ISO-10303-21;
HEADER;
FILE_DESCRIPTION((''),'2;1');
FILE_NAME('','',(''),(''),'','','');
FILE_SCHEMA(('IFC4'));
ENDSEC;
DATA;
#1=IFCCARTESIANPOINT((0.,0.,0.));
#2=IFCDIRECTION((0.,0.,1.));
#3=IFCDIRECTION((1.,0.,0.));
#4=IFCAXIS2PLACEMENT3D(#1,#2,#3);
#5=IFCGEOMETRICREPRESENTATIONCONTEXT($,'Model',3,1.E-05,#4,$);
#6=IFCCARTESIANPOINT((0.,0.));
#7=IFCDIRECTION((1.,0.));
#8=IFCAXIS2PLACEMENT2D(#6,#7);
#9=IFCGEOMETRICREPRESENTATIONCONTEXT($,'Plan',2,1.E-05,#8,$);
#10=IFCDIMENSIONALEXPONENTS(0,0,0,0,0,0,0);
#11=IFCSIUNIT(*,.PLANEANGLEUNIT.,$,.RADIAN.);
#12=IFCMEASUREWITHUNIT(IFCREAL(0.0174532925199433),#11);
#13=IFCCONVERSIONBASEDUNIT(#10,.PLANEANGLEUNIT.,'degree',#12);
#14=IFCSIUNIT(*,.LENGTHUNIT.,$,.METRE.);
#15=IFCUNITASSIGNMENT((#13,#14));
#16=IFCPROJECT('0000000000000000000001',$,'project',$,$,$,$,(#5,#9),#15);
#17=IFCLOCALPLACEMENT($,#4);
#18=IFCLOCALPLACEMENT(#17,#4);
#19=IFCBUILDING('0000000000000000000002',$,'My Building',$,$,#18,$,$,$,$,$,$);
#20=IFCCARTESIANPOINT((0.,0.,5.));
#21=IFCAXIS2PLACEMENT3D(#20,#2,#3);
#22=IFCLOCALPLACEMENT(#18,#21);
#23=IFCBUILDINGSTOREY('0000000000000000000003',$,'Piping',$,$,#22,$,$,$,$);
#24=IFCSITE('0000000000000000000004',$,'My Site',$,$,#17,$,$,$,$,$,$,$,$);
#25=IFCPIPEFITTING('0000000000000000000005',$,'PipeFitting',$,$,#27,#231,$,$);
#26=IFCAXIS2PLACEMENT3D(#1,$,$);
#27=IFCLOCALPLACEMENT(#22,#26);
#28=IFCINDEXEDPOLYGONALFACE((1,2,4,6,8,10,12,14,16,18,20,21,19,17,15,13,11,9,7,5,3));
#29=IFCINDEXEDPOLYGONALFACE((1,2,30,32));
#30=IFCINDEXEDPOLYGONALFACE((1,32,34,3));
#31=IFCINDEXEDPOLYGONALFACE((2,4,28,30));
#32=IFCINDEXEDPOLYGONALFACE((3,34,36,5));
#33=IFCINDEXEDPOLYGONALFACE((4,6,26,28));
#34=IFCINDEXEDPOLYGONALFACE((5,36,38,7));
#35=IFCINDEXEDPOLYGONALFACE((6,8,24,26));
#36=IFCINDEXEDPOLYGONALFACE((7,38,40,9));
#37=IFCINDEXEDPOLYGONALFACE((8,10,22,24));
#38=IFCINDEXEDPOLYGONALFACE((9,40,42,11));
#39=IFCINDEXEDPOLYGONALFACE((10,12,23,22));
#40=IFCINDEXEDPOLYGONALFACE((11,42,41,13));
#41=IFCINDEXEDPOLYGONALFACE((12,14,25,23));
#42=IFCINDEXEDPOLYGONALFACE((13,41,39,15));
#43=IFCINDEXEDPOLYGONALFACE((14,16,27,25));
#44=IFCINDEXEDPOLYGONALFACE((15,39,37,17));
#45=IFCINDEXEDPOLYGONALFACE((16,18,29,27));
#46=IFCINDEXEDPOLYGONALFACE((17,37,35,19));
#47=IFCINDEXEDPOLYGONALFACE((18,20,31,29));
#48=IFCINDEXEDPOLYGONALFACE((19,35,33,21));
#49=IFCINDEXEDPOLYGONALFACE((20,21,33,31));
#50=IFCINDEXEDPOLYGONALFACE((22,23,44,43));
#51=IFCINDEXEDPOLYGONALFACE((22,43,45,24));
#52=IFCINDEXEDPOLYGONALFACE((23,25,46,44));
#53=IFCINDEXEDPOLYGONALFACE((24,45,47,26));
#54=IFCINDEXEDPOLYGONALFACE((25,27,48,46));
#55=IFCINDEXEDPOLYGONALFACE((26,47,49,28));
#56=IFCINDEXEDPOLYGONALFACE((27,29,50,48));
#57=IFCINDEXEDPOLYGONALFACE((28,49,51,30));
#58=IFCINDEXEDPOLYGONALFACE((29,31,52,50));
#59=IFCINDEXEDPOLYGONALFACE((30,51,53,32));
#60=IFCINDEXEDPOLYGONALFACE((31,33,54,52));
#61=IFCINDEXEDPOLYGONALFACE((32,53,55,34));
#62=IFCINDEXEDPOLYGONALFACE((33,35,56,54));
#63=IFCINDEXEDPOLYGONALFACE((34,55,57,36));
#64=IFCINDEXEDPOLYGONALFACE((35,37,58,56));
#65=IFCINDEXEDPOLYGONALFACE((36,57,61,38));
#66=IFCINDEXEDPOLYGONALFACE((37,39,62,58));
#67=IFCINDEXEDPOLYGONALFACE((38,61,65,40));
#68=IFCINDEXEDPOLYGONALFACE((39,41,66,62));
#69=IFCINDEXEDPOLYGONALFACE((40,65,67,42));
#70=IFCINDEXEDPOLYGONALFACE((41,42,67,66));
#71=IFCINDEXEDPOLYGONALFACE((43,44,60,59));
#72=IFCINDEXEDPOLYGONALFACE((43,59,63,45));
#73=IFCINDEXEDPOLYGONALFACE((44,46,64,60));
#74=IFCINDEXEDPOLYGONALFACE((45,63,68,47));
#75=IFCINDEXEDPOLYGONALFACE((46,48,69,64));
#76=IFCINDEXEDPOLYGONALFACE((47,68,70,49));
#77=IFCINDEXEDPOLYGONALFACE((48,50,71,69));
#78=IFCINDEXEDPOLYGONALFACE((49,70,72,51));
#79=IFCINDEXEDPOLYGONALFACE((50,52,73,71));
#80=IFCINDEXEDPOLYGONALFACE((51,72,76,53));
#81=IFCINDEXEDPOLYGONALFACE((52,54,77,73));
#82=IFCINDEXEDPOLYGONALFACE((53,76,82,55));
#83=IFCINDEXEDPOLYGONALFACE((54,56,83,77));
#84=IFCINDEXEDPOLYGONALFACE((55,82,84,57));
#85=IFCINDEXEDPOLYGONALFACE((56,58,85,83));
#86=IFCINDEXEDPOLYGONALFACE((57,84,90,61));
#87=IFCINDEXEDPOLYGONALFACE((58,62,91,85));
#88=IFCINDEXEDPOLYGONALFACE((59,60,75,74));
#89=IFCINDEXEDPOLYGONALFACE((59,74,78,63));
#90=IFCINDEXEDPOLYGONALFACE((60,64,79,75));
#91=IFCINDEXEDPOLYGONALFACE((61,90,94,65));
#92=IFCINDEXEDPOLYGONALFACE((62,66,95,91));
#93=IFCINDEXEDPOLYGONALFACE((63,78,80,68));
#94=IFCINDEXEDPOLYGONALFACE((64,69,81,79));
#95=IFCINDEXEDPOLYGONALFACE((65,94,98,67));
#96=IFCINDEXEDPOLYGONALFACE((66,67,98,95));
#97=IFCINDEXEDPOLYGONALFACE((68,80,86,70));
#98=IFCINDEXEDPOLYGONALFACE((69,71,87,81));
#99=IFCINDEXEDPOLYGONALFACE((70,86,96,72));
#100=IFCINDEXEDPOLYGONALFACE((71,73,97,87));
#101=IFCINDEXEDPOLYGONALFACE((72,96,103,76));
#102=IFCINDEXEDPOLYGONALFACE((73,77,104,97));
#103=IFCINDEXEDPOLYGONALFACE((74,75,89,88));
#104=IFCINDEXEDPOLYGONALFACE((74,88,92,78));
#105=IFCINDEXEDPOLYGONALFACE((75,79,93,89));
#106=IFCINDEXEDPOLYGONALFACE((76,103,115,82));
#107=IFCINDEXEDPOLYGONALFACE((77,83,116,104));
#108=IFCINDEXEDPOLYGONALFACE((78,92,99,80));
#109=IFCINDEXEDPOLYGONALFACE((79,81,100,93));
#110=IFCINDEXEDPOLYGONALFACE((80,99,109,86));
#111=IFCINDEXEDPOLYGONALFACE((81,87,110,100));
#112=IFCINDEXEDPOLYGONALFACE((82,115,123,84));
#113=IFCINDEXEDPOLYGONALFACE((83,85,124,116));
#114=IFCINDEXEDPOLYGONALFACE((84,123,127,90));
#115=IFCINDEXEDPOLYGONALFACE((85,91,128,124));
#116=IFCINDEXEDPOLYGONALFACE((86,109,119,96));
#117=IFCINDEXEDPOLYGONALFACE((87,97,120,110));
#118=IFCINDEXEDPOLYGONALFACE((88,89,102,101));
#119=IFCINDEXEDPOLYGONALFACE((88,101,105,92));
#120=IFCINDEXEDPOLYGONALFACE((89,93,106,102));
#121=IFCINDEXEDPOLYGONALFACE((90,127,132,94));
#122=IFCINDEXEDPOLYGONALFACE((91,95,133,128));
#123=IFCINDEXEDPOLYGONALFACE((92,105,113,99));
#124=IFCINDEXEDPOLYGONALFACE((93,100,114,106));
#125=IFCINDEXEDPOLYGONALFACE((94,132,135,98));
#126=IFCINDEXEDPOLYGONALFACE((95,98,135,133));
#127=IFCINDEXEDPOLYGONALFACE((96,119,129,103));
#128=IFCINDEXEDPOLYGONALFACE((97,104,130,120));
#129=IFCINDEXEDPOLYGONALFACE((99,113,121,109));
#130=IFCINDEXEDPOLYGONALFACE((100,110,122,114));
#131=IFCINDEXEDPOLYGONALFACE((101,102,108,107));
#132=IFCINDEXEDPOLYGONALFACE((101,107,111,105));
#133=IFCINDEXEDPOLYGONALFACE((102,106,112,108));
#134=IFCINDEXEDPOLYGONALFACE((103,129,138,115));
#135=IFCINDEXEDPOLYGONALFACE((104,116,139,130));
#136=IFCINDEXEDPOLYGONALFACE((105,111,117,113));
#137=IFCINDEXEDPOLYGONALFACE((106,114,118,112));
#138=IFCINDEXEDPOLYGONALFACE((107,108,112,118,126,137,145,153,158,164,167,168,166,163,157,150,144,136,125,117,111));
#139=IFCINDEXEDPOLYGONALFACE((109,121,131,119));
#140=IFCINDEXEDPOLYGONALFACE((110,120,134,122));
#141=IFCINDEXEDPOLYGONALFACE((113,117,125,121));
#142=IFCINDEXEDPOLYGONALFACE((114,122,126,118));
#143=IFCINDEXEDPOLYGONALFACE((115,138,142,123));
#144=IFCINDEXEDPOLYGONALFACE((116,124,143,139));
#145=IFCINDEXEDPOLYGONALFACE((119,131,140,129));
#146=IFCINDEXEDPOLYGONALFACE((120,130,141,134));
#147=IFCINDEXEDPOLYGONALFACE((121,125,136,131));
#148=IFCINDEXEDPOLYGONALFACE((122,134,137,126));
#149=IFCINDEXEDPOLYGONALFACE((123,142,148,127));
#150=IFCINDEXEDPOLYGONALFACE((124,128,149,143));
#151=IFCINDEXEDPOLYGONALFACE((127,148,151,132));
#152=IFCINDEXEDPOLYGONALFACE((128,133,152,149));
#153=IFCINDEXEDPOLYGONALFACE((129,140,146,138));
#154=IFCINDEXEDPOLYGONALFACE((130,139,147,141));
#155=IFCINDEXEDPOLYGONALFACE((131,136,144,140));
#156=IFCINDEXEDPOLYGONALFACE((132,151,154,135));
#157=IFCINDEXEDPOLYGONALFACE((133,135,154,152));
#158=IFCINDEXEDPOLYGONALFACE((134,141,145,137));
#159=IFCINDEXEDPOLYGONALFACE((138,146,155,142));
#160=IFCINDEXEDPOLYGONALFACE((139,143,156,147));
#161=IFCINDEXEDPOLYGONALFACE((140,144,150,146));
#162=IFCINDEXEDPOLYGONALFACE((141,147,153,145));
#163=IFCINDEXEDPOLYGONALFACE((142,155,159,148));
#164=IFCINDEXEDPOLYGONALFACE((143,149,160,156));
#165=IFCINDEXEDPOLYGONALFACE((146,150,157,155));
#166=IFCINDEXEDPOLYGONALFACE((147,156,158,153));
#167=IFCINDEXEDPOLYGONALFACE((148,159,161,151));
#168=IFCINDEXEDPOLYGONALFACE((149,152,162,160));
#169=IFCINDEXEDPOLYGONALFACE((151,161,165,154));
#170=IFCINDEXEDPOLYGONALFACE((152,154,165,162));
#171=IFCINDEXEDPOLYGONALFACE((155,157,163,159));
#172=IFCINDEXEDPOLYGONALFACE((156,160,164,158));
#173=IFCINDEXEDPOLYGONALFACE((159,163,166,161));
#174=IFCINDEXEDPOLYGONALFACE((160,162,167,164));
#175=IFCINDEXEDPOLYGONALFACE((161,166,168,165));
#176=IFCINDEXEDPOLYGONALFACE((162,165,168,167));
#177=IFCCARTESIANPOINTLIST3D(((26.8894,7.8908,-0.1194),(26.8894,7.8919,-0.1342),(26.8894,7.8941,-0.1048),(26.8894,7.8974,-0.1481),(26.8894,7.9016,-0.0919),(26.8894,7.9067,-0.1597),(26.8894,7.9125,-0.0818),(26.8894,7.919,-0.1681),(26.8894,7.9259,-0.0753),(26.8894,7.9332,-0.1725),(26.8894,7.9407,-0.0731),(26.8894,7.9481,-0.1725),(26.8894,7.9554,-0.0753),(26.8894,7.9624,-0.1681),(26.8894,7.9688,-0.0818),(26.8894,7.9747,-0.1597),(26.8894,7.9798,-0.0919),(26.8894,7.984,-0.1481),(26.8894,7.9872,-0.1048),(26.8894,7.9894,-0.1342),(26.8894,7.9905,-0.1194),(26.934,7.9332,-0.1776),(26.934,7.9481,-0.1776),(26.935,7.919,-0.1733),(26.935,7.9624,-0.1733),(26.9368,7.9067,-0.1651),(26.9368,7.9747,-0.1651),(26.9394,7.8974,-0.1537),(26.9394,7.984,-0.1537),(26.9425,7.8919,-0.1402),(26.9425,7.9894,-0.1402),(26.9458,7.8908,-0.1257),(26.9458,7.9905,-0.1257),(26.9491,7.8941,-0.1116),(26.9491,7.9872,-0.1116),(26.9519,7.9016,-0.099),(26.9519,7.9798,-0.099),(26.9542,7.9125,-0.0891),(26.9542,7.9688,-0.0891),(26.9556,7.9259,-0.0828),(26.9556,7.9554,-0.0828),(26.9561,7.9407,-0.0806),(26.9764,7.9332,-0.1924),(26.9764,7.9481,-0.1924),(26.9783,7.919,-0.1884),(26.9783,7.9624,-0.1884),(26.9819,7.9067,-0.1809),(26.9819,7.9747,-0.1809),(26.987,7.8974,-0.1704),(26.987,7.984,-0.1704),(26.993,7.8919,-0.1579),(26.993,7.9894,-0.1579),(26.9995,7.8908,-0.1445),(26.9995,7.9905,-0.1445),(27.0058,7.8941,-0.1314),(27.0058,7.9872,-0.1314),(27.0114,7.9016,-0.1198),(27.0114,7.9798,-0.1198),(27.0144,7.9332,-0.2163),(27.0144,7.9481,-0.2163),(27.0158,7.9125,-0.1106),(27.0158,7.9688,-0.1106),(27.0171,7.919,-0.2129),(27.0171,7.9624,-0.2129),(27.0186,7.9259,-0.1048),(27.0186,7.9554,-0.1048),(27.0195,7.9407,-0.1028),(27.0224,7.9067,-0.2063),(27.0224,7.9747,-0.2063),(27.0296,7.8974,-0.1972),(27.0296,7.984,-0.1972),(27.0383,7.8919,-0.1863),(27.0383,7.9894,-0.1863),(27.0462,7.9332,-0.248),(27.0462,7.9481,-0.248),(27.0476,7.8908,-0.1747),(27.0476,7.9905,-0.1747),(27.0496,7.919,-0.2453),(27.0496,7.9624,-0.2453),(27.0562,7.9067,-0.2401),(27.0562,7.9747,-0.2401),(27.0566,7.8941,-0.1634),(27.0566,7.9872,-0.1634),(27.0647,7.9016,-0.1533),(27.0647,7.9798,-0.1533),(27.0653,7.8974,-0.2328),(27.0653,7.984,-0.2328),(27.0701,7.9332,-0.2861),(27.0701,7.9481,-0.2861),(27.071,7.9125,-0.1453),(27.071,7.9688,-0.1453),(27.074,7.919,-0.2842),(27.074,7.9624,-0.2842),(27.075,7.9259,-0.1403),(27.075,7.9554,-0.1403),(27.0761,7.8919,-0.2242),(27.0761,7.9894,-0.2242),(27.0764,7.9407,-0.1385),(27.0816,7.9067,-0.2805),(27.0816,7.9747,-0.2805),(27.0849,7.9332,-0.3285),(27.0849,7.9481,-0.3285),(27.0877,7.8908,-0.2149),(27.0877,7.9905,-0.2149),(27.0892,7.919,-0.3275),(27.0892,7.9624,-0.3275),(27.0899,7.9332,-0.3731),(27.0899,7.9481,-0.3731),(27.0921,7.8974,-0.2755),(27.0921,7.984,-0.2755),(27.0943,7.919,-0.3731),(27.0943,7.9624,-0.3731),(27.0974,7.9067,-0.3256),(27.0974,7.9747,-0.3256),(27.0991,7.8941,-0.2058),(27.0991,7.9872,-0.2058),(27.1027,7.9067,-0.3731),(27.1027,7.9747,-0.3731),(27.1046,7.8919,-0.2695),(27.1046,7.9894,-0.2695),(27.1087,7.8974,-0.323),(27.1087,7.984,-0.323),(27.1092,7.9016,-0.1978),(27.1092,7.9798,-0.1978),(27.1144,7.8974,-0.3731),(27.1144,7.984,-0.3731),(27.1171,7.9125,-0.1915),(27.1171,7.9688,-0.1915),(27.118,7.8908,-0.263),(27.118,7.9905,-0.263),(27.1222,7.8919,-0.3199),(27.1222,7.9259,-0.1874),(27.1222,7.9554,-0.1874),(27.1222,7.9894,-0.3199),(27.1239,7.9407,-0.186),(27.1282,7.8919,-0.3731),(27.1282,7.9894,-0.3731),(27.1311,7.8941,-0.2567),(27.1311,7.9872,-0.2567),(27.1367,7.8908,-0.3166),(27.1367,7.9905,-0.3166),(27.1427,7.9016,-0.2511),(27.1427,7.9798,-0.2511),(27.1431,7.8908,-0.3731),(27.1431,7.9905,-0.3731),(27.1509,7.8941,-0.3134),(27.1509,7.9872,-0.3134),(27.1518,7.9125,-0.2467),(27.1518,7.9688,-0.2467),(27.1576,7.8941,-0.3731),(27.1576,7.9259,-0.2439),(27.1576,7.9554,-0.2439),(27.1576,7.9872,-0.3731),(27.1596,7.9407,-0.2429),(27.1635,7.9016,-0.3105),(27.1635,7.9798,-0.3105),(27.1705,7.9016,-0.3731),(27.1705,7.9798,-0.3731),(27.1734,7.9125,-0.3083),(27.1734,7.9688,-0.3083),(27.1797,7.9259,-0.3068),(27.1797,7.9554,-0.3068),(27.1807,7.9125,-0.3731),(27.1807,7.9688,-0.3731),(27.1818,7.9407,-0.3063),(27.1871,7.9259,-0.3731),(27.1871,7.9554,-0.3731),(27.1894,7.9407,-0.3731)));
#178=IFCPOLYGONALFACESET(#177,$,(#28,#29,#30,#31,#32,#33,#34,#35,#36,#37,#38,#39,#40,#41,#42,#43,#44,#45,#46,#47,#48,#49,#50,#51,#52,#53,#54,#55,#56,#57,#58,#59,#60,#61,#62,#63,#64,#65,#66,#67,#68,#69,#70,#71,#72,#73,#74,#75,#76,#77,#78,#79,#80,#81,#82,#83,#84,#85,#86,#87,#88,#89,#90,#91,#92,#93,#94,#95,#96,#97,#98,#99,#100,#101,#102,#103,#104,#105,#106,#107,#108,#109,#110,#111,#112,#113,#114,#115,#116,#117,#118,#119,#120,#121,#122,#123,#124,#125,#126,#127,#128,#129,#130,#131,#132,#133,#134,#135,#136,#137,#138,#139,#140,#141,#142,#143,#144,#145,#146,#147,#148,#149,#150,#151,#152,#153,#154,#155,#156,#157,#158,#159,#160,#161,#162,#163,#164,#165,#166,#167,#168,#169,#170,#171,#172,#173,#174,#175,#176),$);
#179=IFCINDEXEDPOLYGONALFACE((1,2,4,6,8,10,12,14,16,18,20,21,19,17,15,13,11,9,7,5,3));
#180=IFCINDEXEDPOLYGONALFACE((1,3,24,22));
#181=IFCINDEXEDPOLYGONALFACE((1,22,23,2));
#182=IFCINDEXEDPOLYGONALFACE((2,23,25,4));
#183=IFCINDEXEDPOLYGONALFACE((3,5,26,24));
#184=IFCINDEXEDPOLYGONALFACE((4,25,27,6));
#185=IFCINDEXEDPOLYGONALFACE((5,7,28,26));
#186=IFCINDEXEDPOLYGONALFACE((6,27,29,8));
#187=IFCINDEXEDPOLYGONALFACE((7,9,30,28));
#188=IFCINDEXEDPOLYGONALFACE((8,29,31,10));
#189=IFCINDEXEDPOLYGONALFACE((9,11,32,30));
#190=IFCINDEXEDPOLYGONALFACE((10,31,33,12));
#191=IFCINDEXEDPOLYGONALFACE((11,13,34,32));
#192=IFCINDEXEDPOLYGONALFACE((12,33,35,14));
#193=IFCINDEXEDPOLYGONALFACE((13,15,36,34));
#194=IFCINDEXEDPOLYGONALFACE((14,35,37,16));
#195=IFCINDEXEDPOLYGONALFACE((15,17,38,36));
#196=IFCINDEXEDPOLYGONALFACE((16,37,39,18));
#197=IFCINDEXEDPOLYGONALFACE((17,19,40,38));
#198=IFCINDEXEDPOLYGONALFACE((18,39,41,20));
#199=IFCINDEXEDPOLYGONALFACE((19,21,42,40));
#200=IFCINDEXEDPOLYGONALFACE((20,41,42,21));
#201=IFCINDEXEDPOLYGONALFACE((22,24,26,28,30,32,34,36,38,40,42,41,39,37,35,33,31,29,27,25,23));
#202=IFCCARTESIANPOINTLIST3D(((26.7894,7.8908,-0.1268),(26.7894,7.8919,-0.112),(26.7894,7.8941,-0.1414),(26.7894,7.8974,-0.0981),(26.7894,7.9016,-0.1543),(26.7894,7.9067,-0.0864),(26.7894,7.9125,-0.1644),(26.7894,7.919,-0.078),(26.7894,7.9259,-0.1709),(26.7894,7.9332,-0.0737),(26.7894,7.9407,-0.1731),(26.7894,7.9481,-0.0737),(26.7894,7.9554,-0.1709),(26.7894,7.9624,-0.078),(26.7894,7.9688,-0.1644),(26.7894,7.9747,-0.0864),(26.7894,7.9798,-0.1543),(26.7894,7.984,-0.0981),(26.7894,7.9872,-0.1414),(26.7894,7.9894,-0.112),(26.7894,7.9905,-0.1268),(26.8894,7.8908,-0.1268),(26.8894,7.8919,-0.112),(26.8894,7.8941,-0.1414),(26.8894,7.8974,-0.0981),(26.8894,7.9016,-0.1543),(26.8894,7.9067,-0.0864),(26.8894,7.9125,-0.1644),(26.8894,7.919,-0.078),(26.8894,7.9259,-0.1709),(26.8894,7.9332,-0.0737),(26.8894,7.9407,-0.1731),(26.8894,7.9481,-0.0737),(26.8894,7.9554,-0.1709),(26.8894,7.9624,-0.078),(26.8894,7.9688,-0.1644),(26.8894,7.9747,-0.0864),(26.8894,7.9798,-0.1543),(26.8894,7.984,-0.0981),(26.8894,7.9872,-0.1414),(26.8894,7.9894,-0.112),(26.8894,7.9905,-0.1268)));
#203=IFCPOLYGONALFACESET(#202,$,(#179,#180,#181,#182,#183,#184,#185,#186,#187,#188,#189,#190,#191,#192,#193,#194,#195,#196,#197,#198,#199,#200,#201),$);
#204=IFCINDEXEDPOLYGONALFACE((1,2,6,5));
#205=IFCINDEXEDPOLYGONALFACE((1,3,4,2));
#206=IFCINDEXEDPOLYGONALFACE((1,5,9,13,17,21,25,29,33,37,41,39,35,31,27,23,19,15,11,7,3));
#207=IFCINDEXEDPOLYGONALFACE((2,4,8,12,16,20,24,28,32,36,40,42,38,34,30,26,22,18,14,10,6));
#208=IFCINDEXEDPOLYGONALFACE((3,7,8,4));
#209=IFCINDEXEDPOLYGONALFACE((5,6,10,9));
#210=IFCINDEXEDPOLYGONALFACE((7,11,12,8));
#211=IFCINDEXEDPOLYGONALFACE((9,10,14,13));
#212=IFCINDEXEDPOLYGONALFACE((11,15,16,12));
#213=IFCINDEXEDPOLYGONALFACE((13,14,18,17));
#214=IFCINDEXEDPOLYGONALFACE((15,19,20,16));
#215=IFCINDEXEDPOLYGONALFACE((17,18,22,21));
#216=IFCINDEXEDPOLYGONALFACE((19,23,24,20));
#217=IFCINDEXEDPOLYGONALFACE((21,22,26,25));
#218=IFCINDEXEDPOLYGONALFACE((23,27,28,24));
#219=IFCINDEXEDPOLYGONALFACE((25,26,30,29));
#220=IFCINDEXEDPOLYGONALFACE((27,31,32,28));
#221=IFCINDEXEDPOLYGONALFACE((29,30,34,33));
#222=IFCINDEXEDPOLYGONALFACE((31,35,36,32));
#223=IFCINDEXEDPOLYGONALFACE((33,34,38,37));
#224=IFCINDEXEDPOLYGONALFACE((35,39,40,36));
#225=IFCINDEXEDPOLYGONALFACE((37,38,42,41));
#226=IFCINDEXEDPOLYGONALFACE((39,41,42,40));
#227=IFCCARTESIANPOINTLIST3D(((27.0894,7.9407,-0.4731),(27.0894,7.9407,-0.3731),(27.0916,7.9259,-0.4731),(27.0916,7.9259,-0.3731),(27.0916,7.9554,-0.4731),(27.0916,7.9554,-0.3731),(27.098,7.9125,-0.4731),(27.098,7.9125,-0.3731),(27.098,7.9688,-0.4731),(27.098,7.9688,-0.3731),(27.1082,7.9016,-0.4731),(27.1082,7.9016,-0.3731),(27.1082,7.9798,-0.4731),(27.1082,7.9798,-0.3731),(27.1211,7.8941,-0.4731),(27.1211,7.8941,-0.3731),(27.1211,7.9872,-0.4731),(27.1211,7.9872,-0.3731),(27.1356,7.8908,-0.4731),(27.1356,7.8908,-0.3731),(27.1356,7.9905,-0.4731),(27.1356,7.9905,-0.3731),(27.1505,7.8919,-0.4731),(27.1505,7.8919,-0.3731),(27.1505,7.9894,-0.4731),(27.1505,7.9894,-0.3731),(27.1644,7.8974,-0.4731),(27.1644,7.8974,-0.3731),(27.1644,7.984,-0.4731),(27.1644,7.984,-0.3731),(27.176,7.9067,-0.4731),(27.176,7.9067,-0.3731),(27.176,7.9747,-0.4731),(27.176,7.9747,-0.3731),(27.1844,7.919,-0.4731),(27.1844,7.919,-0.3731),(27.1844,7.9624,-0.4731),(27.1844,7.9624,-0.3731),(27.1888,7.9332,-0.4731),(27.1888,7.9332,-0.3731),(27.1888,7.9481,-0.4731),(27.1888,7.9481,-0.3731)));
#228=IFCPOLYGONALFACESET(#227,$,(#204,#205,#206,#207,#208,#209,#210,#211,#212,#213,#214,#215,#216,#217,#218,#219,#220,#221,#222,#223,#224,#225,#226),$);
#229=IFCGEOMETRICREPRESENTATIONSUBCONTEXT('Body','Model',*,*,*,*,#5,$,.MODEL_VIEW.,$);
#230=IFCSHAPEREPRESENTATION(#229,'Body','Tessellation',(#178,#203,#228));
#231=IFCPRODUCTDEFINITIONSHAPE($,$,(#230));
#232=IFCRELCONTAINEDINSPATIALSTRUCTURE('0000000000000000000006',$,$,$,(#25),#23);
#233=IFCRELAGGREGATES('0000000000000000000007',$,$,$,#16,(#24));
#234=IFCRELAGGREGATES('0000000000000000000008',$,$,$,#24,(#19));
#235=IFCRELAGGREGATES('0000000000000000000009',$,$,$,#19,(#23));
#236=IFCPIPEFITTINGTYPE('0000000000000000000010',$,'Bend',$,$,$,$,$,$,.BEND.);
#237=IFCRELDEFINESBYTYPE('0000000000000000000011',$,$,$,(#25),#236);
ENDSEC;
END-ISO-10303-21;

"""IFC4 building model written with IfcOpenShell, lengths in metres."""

from ifc_helpers import new_model, entity, si_unit, converted_unit, frame, origin_with_axes, origin_2d_with_axis, place, context, subcontext, project, spatial, circle, extrude, source, transform, mapped, type_object, type_shapes, element, save


model = new_model("IFC4")

# Units and contexts
model_context = context("Model", 3, precision=1e-05, world=origin_with_axes())
plan_context = context("Plan", 2, precision=1e-05, world=origin_2d_with_axis())
body_context = subcontext(model_context, "Body", "Model", "MODEL_VIEW")
ifc_project = project(units=[converted_unit("PLANEANGLEUNIT", "degree", entity("IfcReal", 0.0174532925199433), si_unit("PLANEANGLEUNIT", "RADIAN"), dimensions=[0, 0, 0, 0, 0, 0, 0]), si_unit("LENGTHUNIT", "METRE")], contexts=[model_context, plan_context])

# Site, building, storey
site_placement = place(None, origin_with_axes())
site = spatial("IfcSite", under=ifc_project, at=site_placement, Name="My Site")
building_placement = place(site_placement, origin_with_axes())
building = spatial("IfcBuilding", under=site, at=building_placement, Name="My Building")
storey_placement = place(building_placement, frame((0.0, 0.0, 5.0), z_axis=(0.0, 0.0, 1.0), x_axis=(1.0, 0.0, 0.0)))
storey = spatial("IfcBuildingStorey", under=building, at=storey_placement, Name="Piping")

# Pipe fitting
pipe_fitting_type_1 = type_object("IfcPipeFittingType", Name="Bend", PredefinedType="BEND")
shared_shape = source(origin_with_axes(), body_context, "Body", "SolidModel", [
    entity("IfcSweptDiskSolid", entity("IfcIndexedPolyCurve", entity("IfcCartesianPointList3D", [[0.0, 0.0, -0.1], [0.0732, 0.0, -0.2768], [0.25, 0.0, -0.35]]), [entity("IfcArcIndex", [1, 2, 3])]), 0.05),
    extrude(circle(Radius=0.05), origin_with_axes(), (0.0, 0.0, -1.0), 0.1),
    extrude(circle(Radius=0.05), frame((0.25, 0.0, -0.35), z_axis=(1.0, 0.0, 0.0), x_axis=(0.0, 0.0, 1.0)), (0.0, 0.0, 1.0), 0.1),
])
type_shapes(pipe_fitting_type_1, [shared_shape])
for number, where, z_axis, x_axis, name in (
    (1, (26.7894, 7.9407, -0.1231), (-1.0, -0.000001, 0.0), (0.0, 0.0, -1.0), "PipeFitting"),
):
    element("IfcPipeFitting", number, at=place(storey_placement, frame(where, z_axis=z_axis, x_axis=x_axis)), inside=storey, type_object=pipe_fitting_type_1, Name=name, context=body_context, shape_type="MappedRepresentation", body=[
        mapped(shared_shape, transform((0.0, 0.0, 0.0), x_axis=(1.0, 0.0, 0.0), y_axis=(0.0, 1.0, 0.0), z_axis=(0.0, 0.0, 1.0), scale=1.0)),
    ])

save(model, "model.ifc")
